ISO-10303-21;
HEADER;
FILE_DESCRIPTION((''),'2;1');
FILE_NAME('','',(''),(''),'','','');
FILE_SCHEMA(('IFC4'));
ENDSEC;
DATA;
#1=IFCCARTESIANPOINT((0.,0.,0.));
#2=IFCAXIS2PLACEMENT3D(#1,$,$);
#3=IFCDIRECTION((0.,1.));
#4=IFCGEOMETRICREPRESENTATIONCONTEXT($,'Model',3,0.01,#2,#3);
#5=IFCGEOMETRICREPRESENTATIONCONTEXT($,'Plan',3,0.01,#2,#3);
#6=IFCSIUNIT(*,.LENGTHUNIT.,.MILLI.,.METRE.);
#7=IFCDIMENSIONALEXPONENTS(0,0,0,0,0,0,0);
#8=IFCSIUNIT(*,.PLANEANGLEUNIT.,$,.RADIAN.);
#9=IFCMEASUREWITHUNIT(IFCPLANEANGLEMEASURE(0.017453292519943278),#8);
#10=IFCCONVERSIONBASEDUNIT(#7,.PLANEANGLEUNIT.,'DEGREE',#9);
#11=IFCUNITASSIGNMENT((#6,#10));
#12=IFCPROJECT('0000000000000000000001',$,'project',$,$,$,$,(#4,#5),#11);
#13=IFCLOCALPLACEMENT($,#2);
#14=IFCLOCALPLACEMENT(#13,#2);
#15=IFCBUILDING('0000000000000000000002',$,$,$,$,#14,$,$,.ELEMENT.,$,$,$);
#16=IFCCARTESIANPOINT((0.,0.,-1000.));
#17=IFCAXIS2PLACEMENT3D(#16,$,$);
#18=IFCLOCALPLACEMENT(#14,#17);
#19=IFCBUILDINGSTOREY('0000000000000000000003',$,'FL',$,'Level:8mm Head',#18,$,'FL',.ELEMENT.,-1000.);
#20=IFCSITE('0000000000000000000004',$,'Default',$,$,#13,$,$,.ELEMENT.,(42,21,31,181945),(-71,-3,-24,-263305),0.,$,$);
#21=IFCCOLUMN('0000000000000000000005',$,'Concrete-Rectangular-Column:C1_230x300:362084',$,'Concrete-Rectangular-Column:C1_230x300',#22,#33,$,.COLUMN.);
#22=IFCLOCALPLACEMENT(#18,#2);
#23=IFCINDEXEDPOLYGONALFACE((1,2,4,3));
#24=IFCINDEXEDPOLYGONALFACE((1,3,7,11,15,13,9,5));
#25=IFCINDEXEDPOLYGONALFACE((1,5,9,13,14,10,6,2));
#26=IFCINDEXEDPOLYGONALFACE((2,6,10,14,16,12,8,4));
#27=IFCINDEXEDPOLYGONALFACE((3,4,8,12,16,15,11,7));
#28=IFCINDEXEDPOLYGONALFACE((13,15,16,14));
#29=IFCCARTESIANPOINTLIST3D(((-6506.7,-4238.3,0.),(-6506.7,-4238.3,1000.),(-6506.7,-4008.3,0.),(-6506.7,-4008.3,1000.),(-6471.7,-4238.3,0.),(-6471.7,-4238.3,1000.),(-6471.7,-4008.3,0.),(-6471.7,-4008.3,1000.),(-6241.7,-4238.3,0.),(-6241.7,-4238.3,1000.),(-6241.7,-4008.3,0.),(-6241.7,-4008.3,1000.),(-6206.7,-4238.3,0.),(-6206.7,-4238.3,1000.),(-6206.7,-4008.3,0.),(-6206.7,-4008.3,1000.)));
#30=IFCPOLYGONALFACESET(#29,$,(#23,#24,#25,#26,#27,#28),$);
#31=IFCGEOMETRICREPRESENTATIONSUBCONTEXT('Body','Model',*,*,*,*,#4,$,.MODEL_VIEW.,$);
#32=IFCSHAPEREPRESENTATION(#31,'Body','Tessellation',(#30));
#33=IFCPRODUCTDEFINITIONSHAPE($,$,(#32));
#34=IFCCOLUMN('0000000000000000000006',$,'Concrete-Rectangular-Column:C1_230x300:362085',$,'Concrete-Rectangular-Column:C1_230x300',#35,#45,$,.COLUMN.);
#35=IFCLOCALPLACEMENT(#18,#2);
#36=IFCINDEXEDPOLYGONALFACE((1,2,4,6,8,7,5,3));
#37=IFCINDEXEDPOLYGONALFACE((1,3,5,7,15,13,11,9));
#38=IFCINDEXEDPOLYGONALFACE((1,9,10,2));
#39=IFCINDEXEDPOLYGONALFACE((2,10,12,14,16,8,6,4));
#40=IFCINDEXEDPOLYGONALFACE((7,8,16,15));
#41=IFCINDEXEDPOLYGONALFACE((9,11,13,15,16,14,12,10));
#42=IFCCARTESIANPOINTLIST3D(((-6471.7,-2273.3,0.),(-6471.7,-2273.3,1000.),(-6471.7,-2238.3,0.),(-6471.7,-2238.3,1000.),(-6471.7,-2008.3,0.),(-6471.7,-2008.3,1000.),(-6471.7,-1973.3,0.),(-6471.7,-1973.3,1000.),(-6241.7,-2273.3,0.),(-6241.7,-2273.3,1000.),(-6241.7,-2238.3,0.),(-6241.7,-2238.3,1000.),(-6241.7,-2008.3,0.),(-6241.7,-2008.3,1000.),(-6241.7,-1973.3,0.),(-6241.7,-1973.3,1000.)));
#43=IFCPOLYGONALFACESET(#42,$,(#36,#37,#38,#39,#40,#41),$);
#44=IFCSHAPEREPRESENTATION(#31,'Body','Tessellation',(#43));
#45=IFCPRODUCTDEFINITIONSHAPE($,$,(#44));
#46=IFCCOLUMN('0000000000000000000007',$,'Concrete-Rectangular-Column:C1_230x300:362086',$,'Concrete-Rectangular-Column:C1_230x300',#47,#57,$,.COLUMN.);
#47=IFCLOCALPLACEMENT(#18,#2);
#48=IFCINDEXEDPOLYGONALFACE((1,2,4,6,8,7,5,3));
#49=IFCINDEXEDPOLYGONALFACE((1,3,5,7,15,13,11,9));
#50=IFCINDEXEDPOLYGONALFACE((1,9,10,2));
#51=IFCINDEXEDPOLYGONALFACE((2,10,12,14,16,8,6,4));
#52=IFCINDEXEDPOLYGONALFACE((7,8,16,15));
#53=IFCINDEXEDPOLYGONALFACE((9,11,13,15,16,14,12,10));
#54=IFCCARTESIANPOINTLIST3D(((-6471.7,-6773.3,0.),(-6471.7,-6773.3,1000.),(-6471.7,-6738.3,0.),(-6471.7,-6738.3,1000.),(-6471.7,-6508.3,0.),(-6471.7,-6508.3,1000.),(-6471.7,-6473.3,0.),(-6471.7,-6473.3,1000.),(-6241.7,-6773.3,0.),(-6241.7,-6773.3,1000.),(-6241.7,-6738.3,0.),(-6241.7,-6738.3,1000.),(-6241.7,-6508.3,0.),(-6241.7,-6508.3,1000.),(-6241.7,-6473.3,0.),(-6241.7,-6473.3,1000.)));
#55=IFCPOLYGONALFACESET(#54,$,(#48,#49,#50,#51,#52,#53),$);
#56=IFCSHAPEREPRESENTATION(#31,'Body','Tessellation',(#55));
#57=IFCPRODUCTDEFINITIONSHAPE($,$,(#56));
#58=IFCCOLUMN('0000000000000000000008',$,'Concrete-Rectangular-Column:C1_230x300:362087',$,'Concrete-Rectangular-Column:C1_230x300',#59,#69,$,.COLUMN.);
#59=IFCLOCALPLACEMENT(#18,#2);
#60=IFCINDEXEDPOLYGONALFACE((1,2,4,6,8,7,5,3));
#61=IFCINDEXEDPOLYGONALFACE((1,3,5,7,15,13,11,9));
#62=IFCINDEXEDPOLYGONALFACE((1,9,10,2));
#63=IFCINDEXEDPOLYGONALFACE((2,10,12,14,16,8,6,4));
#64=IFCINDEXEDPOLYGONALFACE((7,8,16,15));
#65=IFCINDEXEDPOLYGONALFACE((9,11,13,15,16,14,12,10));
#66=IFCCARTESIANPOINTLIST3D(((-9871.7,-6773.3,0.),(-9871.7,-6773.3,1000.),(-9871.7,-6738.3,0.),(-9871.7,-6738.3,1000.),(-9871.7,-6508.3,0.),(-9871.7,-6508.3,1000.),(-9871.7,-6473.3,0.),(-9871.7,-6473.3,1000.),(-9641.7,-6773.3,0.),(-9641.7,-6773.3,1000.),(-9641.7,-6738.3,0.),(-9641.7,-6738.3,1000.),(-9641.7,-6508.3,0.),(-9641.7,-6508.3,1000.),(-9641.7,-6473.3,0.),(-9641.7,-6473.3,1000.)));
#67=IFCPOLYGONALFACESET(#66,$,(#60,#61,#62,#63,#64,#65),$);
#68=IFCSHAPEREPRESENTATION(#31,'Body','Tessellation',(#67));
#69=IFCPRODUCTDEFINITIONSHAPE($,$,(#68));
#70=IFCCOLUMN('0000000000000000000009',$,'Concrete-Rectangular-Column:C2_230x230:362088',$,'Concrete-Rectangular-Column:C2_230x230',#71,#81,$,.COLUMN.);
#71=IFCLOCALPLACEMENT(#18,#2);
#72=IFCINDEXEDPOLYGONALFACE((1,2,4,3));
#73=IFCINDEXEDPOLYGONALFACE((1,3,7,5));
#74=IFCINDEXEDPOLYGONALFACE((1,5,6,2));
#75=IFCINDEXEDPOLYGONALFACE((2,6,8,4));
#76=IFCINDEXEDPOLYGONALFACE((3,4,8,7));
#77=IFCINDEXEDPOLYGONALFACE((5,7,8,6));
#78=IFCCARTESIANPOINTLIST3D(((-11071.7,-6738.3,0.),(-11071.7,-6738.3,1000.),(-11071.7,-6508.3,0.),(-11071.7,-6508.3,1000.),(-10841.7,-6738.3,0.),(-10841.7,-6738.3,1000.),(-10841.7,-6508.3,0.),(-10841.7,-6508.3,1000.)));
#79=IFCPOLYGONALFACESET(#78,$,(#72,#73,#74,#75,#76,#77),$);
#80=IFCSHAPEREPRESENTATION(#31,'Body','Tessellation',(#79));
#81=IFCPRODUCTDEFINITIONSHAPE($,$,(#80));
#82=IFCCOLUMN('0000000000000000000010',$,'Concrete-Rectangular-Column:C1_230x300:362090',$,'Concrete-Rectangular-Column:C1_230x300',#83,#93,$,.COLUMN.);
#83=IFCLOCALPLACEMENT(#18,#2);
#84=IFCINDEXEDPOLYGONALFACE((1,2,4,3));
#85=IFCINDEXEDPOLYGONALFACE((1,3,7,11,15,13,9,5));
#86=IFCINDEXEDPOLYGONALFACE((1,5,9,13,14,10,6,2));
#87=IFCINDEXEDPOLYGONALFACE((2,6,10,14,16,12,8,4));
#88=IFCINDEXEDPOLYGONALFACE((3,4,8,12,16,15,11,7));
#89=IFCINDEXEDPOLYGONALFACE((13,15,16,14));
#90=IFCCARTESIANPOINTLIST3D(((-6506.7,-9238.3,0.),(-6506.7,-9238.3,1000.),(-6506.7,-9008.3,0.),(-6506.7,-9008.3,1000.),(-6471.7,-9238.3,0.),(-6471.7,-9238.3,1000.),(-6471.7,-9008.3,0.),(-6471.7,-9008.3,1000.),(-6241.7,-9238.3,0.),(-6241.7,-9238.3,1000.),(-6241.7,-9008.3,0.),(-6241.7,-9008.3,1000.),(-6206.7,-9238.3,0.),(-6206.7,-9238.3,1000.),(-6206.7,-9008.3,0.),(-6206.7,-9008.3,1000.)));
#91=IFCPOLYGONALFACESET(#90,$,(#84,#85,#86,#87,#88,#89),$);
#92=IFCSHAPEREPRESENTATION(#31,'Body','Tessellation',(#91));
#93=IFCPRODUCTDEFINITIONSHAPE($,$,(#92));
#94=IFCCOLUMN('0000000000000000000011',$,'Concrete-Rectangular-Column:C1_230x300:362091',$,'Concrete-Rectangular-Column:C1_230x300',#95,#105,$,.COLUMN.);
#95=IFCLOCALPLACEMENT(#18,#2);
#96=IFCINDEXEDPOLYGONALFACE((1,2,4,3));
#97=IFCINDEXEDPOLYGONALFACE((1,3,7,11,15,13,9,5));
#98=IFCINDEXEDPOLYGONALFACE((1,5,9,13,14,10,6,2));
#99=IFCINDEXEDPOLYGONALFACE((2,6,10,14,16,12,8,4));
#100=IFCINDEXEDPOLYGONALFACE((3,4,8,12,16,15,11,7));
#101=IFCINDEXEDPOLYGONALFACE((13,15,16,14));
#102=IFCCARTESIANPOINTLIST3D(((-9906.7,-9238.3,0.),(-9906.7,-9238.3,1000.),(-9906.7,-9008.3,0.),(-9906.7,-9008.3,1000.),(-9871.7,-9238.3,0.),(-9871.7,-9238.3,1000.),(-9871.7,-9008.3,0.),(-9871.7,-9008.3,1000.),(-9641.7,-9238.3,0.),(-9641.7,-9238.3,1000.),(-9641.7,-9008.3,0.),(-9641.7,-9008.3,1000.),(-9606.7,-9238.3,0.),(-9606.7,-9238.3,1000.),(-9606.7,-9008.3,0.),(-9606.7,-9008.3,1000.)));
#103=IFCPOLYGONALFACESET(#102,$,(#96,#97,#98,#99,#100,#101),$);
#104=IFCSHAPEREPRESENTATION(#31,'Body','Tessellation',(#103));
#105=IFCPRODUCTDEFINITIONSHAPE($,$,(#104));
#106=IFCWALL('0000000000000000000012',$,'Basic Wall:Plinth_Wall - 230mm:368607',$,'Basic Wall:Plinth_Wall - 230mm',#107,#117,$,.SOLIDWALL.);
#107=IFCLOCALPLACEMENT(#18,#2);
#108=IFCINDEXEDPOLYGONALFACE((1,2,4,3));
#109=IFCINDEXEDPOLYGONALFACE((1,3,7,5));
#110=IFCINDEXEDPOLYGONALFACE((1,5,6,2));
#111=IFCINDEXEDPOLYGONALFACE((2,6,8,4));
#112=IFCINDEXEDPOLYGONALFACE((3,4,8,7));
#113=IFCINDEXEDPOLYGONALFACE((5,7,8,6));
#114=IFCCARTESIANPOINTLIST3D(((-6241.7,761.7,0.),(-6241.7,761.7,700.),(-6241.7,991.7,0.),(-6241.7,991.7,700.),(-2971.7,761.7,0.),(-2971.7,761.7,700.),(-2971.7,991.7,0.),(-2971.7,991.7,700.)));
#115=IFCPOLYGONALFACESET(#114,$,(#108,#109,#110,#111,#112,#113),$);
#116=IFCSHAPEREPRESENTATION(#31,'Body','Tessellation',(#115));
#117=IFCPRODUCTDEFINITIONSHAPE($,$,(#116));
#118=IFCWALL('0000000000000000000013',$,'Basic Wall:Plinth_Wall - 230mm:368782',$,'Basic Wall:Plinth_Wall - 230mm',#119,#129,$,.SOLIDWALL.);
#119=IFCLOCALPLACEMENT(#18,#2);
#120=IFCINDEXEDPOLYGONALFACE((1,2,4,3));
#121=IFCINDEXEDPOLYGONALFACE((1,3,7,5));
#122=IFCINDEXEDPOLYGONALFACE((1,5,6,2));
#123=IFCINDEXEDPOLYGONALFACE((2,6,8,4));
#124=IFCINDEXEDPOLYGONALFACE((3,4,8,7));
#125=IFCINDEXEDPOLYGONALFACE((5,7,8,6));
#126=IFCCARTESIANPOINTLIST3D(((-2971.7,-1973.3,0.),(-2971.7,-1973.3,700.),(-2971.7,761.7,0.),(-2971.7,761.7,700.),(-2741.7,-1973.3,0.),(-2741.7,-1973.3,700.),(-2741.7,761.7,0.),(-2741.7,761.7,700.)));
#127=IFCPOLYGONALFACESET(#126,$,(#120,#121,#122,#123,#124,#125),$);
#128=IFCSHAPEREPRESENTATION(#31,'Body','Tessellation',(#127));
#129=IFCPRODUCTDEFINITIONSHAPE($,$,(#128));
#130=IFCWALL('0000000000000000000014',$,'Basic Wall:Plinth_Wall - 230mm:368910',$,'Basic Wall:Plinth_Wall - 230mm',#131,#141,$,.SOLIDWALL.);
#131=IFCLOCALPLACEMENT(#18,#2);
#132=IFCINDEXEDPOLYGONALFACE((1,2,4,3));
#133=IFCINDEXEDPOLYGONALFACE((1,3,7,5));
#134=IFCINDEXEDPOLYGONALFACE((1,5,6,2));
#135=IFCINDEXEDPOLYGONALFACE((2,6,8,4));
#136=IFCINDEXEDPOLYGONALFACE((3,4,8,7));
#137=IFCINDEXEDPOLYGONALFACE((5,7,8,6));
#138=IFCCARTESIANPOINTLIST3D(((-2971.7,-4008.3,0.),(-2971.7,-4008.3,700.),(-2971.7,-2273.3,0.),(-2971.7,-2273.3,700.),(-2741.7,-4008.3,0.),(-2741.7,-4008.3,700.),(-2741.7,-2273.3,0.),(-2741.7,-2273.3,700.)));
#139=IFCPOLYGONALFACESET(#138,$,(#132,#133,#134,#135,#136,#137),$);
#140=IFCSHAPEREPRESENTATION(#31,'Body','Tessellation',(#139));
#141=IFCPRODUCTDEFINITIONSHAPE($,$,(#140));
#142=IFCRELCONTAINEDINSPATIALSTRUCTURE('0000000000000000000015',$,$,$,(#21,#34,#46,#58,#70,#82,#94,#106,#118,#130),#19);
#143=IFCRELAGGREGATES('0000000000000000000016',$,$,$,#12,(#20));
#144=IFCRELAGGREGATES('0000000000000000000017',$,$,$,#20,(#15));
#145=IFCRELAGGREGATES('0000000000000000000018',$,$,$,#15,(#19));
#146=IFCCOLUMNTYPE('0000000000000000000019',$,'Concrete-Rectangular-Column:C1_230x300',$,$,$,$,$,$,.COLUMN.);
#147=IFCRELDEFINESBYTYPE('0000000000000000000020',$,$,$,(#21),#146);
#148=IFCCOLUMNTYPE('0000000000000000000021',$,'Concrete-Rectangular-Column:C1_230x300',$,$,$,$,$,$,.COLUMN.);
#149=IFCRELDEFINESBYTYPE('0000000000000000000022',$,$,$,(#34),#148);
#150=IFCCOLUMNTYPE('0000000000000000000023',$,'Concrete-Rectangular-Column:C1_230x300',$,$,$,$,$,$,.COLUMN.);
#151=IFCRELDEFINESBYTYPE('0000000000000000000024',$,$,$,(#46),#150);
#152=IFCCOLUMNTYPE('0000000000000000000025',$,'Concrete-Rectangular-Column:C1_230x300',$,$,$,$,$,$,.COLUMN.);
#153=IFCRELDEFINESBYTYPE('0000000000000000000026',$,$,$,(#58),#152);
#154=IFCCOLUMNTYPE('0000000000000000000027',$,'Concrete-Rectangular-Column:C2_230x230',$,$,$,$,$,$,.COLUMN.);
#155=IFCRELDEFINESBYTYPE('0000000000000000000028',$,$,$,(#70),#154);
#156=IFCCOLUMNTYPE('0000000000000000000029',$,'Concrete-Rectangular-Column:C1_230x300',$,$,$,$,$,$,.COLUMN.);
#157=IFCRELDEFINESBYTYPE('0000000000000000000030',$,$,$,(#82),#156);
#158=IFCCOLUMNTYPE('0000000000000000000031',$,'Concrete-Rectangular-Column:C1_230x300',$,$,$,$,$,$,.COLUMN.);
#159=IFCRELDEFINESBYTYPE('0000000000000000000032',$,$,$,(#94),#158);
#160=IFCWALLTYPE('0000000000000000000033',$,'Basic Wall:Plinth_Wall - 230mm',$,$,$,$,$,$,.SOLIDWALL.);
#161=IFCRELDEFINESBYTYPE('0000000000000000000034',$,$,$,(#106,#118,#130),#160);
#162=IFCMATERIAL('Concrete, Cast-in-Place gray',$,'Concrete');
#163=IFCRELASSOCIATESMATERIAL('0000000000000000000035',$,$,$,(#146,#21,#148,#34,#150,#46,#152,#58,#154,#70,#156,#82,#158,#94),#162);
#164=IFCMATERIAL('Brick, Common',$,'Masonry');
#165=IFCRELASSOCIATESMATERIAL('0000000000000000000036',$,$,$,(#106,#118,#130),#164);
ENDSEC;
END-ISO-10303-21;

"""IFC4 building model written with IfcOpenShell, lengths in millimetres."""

from ifc_helpers import new_model, entity, si_unit, converted_unit, direction, frame, origin, place, context, subcontext, project, spatial, indexed_curve, outline, extrude, source, transform, mapped, material, type_object, type_shapes, element, save


model = new_model("IFC4")

# Units and contexts
model_context = context("Model", 3, precision=0.01, world=origin(), true_north=direction((0.0, 1.0)))
plan_context = context("Plan", 3, precision=0.01, world=origin(), true_north=direction((0.0, 1.0)))
body_context = subcontext(model_context, "Body", "Model", "MODEL_VIEW")
ifc_project = project(units=[si_unit("LENGTHUNIT", "METRE", prefix="MILLI"), converted_unit("PLANEANGLEUNIT", "DEGREE", entity("IfcPlaneAngleMeasure", 0.017453292519943278), si_unit("PLANEANGLEUNIT", "RADIAN"), dimensions=[0, 0, 0, 0, 0, 0, 0])], contexts=[model_context, plan_context])

# Site, building, storey
site_placement = place(None, origin())
site = spatial("IfcSite", under=ifc_project, at=site_placement, Name="Default", CompositionType="ELEMENT", RefLatitude=(42, 21, 31, 181945), RefLongitude=(-71, -3, -24, -263305), RefElevation=0.0)
building_placement = place(site_placement, origin())
building = spatial("IfcBuilding", under=site, at=building_placement, CompositionType="ELEMENT")
storey_placement = place(building_placement, frame((0.0, 0.0, -1000.0)))
storey = spatial("IfcBuildingStorey", under=building, at=storey_placement, Name="FL", ObjectType="Level:8mm Head", LongName="FL", CompositionType="ELEMENT", Elevation=-1000.0)

# Shared definitions
ifc_material_1 = material(Name="Concrete, Cast-in-Place gray", Category="Concrete")

# Columns
column_type_1 = type_object("IfcColumnType", Name="Concrete-Rectangular-Column:C1_230x300", PredefinedType="COLUMN", material=ifc_material_1)
shared_shape_1 = source(origin(), body_context, "Body", "SweptSolid", [
    extrude(outline(indexed_curve([(-115.0, -150.0), (115.0, -150.0), (115.0, -115.0), (115.0, 115.0), (115.0, 150.0), (-115.0, 150.0), (-115.0, 115.0), (-115.0, -115.0), (-115.0, -150.0)], self_intersect=False)), frame((-6356.7, -4123.3, -1000.0), z_axis=(0.0, 0.0, 1.0), x_axis=(0.0, 1.0, 0.0)), (0.0, 0.0, 1.0), 1000.0),
])
type_shapes(column_type_1, [shared_shape_1])
column_1_placement = place(storey_placement, frame((0.0, 0.0, 1000.0)))
element("IfcColumn", 1, at=column_1_placement, inside=storey, type_object=column_type_1, material=ifc_material_1, Name="Concrete-Rectangular-Column:C1_230x300:362084", ObjectType="Concrete-Rectangular-Column:C1_230x300", PredefinedType="COLUMN", context=body_context, shape_type="MappedRepresentation", body=[
    mapped(shared_shape_1, transform((0.0, 0.0, 0.0), scale=1.0)),
])
column_type_2 = type_object("IfcColumnType", Name="Concrete-Rectangular-Column:C1_230x300", PredefinedType="COLUMN", material=ifc_material_1)
shared_shape_2 = source(origin(), body_context, "Body", "SweptSolid", [
    extrude(outline(indexed_curve([(-115.0, -150.0), (115.0, -150.0), (115.0, -115.0), (115.0, 115.0), (115.0, 150.0), (-115.0, 150.0), (-115.0, 115.0), (-115.0, -115.0), (-115.0, -150.0)], self_intersect=False)), frame((-6356.7, -2123.3, -1000.0), z_axis=(0.0, 0.0, 1.0), x_axis=(-1.0, 0.0, 0.0)), (0.0, 0.0, 1.0), 1000.0),
])
type_shapes(column_type_2, [shared_shape_2])
column_2_placement = place(storey_placement, frame((0.0, 0.0, 1000.0)))
element("IfcColumn", 2, at=column_2_placement, inside=storey, type_object=column_type_2, material=ifc_material_1, Name="Concrete-Rectangular-Column:C1_230x300:362085", ObjectType="Concrete-Rectangular-Column:C1_230x300", PredefinedType="COLUMN", context=body_context, shape_type="MappedRepresentation", body=[
    mapped(shared_shape_2, transform((0.0, 0.0, 0.0), scale=1.0)),
])
column_type_3 = type_object("IfcColumnType", Name="Concrete-Rectangular-Column:C1_230x300", PredefinedType="COLUMN", material=ifc_material_1)
shared_shape_3 = source(origin(), body_context, "Body", "SweptSolid", [
    extrude(outline(indexed_curve([(-115.0, -150.0), (115.0, -150.0), (115.0, -115.0), (115.0, 115.0), (115.0, 150.0), (-115.0, 150.0), (-115.0, 115.0), (-115.0, -115.0), (-115.0, -150.0)], self_intersect=False)), frame((-6356.7, -6623.3, -1000.0), z_axis=(0.0, 0.0, 1.0), x_axis=(-1.0, 0.0, 0.0)), (0.0, 0.0, 1.0), 1000.0),
])
type_shapes(column_type_3, [shared_shape_3])
column_3_placement = place(storey_placement, frame((0.0, 0.0, 1000.0)))
element("IfcColumn", 3, at=column_3_placement, inside=storey, type_object=column_type_3, material=ifc_material_1, Name="Concrete-Rectangular-Column:C1_230x300:362086", ObjectType="Concrete-Rectangular-Column:C1_230x300", PredefinedType="COLUMN", context=body_context, shape_type="MappedRepresentation", body=[
    mapped(shared_shape_3, transform((0.0, 0.0, 0.0), scale=1.0)),
])
column_type_4 = type_object("IfcColumnType", Name="Concrete-Rectangular-Column:C1_230x300", PredefinedType="COLUMN", material=ifc_material_1)
shared_shape_4 = source(origin(), body_context, "Body", "SweptSolid", [
    extrude(outline(indexed_curve([(-115.0, -150.0), (115.0, -150.0), (115.0, -115.0), (115.0, 115.0), (115.0, 150.0), (-115.0, 150.0), (-115.0, 115.0), (-115.0, -115.0), (-115.0, -150.0)], self_intersect=False)), frame((-9756.7, -6623.3, -1000.0), z_axis=(0.0, 0.0, 1.0), x_axis=(-1.0, 0.0, 0.0)), (0.0, 0.0, 1.0), 1000.0),
])
type_shapes(column_type_4, [shared_shape_4])
column_4_placement = place(storey_placement, frame((0.0, 0.0, 1000.0)))
element("IfcColumn", 4, at=column_4_placement, inside=storey, type_object=column_type_4, material=ifc_material_1, Name="Concrete-Rectangular-Column:C1_230x300:362087", ObjectType="Concrete-Rectangular-Column:C1_230x300", PredefinedType="COLUMN", context=body_context, shape_type="MappedRepresentation", body=[
    mapped(shared_shape_4, transform((0.0, 0.0, 0.0), scale=1.0)),
])
column_type_5 = type_object("IfcColumnType", Name="Concrete-Rectangular-Column:C2_230x230", PredefinedType="COLUMN", material=ifc_material_1)
shared_shape_5 = source(origin(), body_context, "Body", "SweptSolid", [
    extrude(outline(indexed_curve([(-115.0, -115.0), (115.0, -115.0), (115.0, 115.0), (-115.0, 115.0), (-115.0, -115.0)], self_intersect=False)), frame((-10956.7, -6623.3, -1000.0), z_axis=(0.0, 0.0, 1.0), x_axis=(0.0, -1.0, 0.0)), (0.0, 0.0, 1.0), 1000.0),
])
type_shapes(column_type_5, [shared_shape_5])
column_5_placement = place(storey_placement, frame((0.0, 0.0, 1000.0)))
element("IfcColumn", 5, at=column_5_placement, inside=storey, type_object=column_type_5, material=ifc_material_1, Name="Concrete-Rectangular-Column:C2_230x230:362088", ObjectType="Concrete-Rectangular-Column:C2_230x230", PredefinedType="COLUMN", context=body_context, shape_type="MappedRepresentation", body=[
    mapped(shared_shape_5, transform((0.0, 0.0, 0.0), scale=1.0)),
])
column_type_6 = type_object("IfcColumnType", Name="Concrete-Rectangular-Column:C1_230x300", PredefinedType="COLUMN", material=ifc_material_1)
shared_shape_6 = source(origin(), body_context, "Body", "SweptSolid", [
    extrude(outline(indexed_curve([(-115.0, -150.0), (115.0, -150.0), (115.0, -115.0), (115.0, 115.0), (115.0, 150.0), (-115.0, 150.0), (-115.0, 115.0), (-115.0, -115.0), (-115.0, -150.0)], self_intersect=False)), frame((-6356.7, -9123.3, -1000.0), z_axis=(0.0, 0.0, 1.0), x_axis=(0.0, -1.0, 0.0)), (0.0, 0.0, 1.0), 1000.0),
])
type_shapes(column_type_6, [shared_shape_6])
column_6_placement = place(storey_placement, frame((0.0, 0.0, 1000.0)))
element("IfcColumn", 6, at=column_6_placement, inside=storey, type_object=column_type_6, material=ifc_material_1, Name="Concrete-Rectangular-Column:C1_230x300:362090", ObjectType="Concrete-Rectangular-Column:C1_230x300", PredefinedType="COLUMN", context=body_context, shape_type="MappedRepresentation", body=[
    mapped(shared_shape_6, transform((0.0, 0.0, 0.0), scale=1.0)),
])
column_type_7 = type_object("IfcColumnType", Name="Concrete-Rectangular-Column:C1_230x300", PredefinedType="COLUMN", material=ifc_material_1)
shared_shape_7 = source(origin(), body_context, "Body", "SweptSolid", [
    extrude(outline(indexed_curve([(-115.0, -150.0), (115.0, -150.0), (115.0, -115.0), (115.0, 115.0), (115.0, 150.0), (-115.0, 150.0), (-115.0, 115.0), (-115.0, -115.0), (-115.0, -150.0)], self_intersect=False)), frame((-9756.7, -9123.3, -1000.0), z_axis=(0.0, 0.0, 1.0), x_axis=(0.0, -1.0, 0.0)), (0.0, 0.0, 1.0), 1000.0),
])
type_shapes(column_type_7, [shared_shape_7])
column_7_placement = place(storey_placement, frame((0.0, 0.0, 1000.0)))
element("IfcColumn", 7, at=column_7_placement, inside=storey, type_object=column_type_7, material=ifc_material_1, Name="Concrete-Rectangular-Column:C1_230x300:362091", ObjectType="Concrete-Rectangular-Column:C1_230x300", PredefinedType="COLUMN", context=body_context, shape_type="MappedRepresentation", body=[
    mapped(shared_shape_7, transform((0.0, 0.0, 0.0), scale=1.0)),
])

# Walls
ifc_material_2 = material(Name="Brick, Common", Category="Masonry")
wall_type = type_object("IfcWallType", Name="Basic Wall:Plinth_Wall - 230mm", PredefinedType="SOLIDWALL")
wall_1_placement = place(storey_placement, frame((-6241.7, 876.7, 0.0)))
element("IfcWall", 8, at=wall_1_placement, inside=storey, type_object=wall_type, material=ifc_material_2, Name="Basic Wall:Plinth_Wall - 230mm:368607", ObjectType="Basic Wall:Plinth_Wall - 230mm", PredefinedType="SOLIDWALL", context=body_context, shape_type="SweptSolid", body=[
    extrude(outline(indexed_curve([(3270.0, 115.0), (0.0, 115.0), (0.0, -115.0), (3270.0, -115.0), (3270.0, 115.0)], self_intersect=False)), origin(), (0.0, 0.0, 1.0), 700.0),
])
wall_2_placement = place(storey_placement, frame((-2856.7, 761.7, 0.0), z_axis=(0.0, 0.0, 1.0), x_axis=(0.0, -1.0, 0.0)))
element("IfcWall", 9, at=wall_2_placement, inside=storey, type_object=wall_type, material=ifc_material_2, Name="Basic Wall:Plinth_Wall - 230mm:368782", ObjectType="Basic Wall:Plinth_Wall - 230mm", PredefinedType="SOLIDWALL", context=body_context, shape_type="SweptSolid", body=[
    extrude(outline(indexed_curve([(2735.0, 115.0), (0.0, 115.0), (0.0, -115.0), (2735.0, -115.0), (2735.0, 115.0)], self_intersect=False)), origin(), (0.0, 0.0, 1.0), 700.0),
])
wall_3_placement = place(storey_placement, frame((-2856.7, -2273.3, 0.0), z_axis=(0.0, 0.0, 1.0), x_axis=(0.0, -1.0, 0.0)))
element("IfcWall", 10, at=wall_3_placement, inside=storey, type_object=wall_type, material=ifc_material_2, Name="Basic Wall:Plinth_Wall - 230mm:368910", ObjectType="Basic Wall:Plinth_Wall - 230mm", PredefinedType="SOLIDWALL", context=body_context, shape_type="SweptSolid", body=[
    extrude(outline(indexed_curve([(1735.0, 115.0), (0.0, 115.0), (0.0, -115.0), (1735.0, -115.0), (1735.0, 115.0)], self_intersect=False)), origin(), (0.0, 0.0, 1.0), 700.0),
])

save(model, "model.ifc")
